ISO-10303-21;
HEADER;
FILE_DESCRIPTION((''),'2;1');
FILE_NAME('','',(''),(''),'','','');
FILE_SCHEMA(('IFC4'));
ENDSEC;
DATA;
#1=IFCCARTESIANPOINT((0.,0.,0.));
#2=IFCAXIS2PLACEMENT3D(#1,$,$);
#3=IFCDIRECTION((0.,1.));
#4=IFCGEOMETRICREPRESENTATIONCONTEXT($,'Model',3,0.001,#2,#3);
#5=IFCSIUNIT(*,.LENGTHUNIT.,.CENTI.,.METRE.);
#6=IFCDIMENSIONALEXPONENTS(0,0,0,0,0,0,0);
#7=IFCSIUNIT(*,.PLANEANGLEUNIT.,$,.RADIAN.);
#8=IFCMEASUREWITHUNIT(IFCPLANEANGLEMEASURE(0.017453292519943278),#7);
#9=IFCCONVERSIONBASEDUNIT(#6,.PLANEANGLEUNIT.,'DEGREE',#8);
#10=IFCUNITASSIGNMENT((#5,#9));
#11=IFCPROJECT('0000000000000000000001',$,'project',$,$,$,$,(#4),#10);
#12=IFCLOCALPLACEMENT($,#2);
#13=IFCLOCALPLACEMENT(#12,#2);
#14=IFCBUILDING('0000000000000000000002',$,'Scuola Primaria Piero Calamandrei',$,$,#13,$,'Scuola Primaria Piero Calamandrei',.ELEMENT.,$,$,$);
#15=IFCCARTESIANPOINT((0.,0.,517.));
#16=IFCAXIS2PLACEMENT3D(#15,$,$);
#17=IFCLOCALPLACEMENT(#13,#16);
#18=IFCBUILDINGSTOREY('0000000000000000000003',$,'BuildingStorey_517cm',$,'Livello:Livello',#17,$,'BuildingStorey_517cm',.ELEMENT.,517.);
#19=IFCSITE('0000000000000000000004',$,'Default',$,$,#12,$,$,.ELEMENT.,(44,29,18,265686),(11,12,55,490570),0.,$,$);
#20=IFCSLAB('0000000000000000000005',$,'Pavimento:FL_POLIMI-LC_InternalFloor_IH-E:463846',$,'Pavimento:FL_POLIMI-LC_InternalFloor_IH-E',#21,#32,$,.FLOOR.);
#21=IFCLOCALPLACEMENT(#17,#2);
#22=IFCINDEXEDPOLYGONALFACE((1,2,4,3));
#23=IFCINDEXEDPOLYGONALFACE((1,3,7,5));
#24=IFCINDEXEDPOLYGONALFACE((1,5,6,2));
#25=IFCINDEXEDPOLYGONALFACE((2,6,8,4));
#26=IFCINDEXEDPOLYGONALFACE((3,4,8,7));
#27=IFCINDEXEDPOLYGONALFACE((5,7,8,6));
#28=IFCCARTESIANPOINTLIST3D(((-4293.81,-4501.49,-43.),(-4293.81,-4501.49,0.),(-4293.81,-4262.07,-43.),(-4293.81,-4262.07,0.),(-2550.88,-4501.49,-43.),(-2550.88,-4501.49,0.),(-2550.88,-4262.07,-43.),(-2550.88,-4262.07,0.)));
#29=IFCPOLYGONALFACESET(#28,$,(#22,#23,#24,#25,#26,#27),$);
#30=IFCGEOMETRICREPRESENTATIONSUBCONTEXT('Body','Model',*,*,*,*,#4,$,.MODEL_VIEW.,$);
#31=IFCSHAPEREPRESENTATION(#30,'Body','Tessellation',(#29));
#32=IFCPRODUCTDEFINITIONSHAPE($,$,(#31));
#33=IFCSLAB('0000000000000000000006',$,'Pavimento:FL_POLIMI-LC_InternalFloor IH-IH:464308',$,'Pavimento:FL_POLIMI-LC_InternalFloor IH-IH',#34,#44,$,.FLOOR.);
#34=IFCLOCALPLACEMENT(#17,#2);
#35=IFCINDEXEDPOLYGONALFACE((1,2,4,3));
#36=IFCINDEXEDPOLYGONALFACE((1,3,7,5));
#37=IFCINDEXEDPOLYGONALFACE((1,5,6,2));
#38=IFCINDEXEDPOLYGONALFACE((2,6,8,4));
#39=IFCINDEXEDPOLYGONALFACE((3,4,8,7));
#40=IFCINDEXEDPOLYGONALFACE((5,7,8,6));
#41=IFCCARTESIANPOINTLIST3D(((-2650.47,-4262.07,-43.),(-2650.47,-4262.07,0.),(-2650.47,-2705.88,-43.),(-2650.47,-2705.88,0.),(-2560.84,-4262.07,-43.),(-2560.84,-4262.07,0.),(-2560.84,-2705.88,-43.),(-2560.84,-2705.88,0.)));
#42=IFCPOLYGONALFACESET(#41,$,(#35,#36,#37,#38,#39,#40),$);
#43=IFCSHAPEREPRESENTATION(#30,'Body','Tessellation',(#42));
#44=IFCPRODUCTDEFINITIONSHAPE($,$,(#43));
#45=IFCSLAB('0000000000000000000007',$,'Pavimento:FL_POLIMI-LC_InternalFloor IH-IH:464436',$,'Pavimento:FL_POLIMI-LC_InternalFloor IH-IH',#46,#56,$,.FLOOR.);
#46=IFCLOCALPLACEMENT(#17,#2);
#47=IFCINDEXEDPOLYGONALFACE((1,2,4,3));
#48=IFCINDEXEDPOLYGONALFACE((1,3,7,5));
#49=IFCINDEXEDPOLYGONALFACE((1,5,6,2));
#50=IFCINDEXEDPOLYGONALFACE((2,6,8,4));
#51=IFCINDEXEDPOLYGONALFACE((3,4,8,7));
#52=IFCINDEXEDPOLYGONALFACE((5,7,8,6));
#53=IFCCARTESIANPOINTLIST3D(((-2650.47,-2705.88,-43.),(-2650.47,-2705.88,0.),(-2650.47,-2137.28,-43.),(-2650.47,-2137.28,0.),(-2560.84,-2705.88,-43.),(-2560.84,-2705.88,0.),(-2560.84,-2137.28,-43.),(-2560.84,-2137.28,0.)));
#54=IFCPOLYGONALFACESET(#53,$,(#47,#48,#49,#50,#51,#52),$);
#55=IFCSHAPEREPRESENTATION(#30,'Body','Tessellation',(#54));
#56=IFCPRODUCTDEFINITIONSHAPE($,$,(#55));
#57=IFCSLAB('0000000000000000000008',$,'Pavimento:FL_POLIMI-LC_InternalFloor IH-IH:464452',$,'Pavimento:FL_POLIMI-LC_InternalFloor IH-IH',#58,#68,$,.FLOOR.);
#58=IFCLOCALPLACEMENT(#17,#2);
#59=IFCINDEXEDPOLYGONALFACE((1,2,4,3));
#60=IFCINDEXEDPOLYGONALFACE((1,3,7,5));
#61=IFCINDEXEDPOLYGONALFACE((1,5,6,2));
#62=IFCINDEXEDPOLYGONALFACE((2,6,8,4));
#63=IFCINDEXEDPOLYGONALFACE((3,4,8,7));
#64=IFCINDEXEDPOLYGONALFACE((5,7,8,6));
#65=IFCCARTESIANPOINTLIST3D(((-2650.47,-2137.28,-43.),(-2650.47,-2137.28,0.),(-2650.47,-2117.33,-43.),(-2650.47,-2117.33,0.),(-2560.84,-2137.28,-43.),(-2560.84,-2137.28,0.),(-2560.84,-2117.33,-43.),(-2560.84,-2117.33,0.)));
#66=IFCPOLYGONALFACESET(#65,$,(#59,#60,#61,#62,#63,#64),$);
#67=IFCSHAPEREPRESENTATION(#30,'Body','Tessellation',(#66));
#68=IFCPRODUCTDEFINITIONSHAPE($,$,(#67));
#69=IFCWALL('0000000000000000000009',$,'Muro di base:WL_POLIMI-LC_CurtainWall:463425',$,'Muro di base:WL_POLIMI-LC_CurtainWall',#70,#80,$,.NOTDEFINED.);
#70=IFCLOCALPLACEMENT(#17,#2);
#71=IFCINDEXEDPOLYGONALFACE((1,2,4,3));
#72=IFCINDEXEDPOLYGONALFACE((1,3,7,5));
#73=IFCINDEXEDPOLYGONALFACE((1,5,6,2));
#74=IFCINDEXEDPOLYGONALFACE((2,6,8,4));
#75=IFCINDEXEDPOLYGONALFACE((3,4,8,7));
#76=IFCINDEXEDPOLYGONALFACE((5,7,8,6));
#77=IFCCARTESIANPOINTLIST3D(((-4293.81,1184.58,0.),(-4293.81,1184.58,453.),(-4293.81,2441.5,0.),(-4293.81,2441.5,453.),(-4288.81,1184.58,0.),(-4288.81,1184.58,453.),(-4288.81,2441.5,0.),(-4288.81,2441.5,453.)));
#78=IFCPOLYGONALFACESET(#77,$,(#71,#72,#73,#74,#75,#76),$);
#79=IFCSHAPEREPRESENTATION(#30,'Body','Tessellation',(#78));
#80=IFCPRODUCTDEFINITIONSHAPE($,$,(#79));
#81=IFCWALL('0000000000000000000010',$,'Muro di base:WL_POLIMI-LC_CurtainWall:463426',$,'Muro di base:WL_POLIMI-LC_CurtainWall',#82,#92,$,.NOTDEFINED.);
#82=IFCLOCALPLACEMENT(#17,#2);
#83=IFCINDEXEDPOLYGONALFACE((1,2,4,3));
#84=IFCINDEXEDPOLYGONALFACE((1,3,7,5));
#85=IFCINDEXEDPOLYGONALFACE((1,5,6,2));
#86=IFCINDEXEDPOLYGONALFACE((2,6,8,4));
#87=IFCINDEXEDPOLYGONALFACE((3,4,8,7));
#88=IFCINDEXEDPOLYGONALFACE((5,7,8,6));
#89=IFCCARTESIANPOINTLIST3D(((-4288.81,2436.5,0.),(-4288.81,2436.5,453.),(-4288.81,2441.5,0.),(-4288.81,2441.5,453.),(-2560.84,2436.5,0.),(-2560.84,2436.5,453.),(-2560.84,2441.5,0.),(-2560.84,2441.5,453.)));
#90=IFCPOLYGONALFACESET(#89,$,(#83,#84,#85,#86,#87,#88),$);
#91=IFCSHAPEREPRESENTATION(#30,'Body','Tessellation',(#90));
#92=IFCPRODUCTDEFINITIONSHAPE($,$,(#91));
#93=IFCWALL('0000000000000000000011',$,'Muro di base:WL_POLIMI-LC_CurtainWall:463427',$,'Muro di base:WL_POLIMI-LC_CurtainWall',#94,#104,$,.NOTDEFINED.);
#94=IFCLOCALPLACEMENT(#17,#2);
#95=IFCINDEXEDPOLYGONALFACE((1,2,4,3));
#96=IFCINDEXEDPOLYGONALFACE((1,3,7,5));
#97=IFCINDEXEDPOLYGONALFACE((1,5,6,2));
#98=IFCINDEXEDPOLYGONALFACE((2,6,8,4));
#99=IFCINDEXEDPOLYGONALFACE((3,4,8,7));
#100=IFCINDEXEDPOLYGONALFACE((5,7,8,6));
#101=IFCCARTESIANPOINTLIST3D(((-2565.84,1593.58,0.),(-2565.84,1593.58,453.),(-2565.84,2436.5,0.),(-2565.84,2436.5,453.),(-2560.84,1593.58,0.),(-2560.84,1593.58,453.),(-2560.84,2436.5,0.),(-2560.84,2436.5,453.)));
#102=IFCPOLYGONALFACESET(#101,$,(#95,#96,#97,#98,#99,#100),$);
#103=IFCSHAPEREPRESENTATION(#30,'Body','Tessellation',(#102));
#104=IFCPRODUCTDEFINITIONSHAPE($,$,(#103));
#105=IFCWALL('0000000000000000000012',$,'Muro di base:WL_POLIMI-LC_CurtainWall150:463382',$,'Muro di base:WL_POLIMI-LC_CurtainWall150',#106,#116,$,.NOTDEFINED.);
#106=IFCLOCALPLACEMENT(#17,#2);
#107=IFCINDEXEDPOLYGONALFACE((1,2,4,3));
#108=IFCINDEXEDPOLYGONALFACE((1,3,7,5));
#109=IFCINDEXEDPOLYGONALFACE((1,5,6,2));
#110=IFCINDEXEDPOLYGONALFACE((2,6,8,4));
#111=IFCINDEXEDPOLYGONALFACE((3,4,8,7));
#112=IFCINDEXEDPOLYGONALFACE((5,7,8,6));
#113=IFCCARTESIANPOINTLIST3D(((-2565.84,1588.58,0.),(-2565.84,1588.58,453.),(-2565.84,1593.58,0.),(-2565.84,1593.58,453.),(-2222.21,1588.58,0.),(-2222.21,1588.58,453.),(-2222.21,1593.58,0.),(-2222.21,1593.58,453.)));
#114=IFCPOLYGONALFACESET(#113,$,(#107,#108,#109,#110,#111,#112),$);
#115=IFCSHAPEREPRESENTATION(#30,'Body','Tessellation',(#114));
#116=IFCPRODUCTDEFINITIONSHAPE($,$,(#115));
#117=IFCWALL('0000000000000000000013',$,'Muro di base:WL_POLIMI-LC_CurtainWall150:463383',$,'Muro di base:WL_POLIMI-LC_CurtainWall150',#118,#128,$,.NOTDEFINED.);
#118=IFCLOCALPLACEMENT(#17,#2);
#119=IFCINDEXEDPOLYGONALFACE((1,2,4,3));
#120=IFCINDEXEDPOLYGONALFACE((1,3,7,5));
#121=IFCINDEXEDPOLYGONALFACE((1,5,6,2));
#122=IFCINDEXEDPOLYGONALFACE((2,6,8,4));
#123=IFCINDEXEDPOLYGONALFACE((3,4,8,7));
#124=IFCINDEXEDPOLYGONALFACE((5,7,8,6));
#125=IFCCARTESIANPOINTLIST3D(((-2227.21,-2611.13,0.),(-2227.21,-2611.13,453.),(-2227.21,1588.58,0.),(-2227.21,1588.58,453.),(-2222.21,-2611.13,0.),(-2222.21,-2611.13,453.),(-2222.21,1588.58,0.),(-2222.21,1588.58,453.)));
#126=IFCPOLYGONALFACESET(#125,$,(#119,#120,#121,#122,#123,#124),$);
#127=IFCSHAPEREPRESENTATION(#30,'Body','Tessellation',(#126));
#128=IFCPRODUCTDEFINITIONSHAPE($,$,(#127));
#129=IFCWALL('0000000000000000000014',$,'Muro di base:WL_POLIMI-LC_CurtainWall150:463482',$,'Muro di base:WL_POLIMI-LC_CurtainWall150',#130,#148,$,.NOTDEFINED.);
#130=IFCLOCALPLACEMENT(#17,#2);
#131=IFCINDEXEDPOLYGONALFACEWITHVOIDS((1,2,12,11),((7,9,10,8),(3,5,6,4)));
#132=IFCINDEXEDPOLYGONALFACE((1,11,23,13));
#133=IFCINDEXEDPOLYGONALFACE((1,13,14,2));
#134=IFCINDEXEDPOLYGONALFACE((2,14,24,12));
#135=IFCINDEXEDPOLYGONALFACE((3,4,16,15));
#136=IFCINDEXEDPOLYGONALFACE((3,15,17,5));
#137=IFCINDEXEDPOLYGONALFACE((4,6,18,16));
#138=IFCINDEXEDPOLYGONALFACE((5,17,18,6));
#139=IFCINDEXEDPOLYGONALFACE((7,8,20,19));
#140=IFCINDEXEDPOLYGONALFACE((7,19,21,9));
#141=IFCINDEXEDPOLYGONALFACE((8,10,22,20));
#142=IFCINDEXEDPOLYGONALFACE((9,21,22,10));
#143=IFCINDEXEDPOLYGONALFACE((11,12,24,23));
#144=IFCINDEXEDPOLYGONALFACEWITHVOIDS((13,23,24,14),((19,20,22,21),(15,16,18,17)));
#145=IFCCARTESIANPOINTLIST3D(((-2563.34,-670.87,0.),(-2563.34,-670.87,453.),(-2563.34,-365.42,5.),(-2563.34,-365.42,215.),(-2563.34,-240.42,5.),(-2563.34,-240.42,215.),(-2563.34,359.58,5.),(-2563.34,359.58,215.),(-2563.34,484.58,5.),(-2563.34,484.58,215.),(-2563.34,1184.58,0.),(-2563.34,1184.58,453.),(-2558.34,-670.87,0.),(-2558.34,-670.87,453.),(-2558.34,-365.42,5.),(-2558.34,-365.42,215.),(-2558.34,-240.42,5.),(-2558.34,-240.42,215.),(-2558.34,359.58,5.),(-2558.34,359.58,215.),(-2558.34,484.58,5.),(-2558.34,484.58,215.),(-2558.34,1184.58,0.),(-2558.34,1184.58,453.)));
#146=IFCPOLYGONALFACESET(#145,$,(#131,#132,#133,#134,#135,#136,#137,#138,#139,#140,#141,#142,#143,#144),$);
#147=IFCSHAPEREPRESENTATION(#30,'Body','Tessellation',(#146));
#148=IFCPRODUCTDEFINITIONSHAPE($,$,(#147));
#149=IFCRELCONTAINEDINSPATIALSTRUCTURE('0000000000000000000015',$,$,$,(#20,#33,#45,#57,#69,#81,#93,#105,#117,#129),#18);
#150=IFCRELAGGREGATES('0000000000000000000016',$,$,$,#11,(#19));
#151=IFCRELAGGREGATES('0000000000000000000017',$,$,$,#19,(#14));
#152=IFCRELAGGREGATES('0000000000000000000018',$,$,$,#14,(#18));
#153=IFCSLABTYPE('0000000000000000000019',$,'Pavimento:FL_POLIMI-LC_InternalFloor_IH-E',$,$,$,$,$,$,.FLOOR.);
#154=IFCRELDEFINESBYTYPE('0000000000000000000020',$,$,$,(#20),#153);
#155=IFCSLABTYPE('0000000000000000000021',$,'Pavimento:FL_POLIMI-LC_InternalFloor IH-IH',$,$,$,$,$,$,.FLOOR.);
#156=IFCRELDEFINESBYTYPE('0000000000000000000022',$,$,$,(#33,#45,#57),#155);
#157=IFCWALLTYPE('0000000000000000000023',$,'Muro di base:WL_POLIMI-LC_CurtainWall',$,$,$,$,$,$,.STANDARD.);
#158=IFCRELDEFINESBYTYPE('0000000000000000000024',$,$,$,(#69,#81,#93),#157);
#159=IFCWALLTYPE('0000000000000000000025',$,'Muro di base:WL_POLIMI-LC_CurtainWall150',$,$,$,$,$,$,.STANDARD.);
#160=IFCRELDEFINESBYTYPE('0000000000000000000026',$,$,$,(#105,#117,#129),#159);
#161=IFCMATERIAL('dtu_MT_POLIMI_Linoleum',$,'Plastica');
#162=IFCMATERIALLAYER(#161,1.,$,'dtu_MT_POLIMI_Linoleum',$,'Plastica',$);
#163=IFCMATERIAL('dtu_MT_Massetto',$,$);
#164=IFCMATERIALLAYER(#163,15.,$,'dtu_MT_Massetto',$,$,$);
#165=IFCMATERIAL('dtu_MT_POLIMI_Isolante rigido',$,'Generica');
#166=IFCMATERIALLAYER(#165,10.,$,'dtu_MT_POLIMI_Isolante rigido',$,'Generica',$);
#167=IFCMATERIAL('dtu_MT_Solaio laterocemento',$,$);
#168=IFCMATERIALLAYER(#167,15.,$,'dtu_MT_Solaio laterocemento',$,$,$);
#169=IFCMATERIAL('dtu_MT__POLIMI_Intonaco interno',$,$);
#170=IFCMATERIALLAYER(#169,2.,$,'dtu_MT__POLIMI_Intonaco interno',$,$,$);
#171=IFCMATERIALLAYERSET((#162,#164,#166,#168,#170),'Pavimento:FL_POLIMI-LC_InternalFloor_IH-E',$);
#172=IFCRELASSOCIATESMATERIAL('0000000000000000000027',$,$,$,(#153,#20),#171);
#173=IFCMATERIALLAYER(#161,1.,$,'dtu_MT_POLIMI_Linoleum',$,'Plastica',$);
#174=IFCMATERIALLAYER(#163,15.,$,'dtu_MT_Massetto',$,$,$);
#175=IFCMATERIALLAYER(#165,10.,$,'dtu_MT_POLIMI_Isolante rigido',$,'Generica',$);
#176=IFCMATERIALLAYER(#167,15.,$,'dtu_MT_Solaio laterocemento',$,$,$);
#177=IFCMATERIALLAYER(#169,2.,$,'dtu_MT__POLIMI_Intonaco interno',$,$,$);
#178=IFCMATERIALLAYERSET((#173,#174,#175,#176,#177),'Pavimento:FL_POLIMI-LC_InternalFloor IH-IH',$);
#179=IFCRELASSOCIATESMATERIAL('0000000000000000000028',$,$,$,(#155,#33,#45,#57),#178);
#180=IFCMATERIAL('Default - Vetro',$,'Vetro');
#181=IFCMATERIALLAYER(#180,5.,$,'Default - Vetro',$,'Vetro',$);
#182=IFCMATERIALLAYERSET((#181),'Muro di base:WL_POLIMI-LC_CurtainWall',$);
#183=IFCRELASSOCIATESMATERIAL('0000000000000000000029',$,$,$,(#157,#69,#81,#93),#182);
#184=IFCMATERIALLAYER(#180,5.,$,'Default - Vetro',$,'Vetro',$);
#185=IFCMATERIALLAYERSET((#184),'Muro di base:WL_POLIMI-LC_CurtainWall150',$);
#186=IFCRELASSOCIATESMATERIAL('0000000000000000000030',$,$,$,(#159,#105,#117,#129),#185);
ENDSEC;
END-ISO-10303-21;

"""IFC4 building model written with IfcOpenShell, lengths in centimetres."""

from ifc_helpers import new_model, entity, si_unit, converted_unit, direction, frame, frame_2d, origin, place, context, subcontext, project, spatial, polyline, rectangle, extrude, clip, bounded_halfspace, material, layer, layer_set, layer_usage, type_object, element, save


model = new_model("IFC4")

# Units and contexts
model_context = context("Model", 3, precision=0.001, world=origin(), true_north=direction((0.0, 1.0)))
body_context = subcontext(model_context, "Body", "Model", "MODEL_VIEW")
ifc_project = project(units=[si_unit("LENGTHUNIT", "METRE", prefix="CENTI"), converted_unit("PLANEANGLEUNIT", "DEGREE", entity("IfcPlaneAngleMeasure", 0.017453292519943278), si_unit("PLANEANGLEUNIT", "RADIAN"), dimensions=[0, 0, 0, 0, 0, 0, 0])], contexts=[model_context])

# Site, building, storey
site_placement = place(None, origin())
site = spatial("IfcSite", under=ifc_project, at=site_placement, Name="Default", CompositionType="ELEMENT", RefLatitude=(44, 29, 18, 265686), RefLongitude=(11, 12, 55, 490570), RefElevation=0.0)
building_placement = place(site_placement, origin())
building = spatial("IfcBuilding", under=site, at=building_placement, Name="Scuola Primaria Piero Calamandrei", LongName="Scuola Primaria Piero Calamandrei", CompositionType="ELEMENT")
storey_placement = place(building_placement, frame((0.0, 0.0, 517.0)))
storey = spatial("IfcBuildingStorey", under=building, at=storey_placement, Name="BuildingStorey_517cm", ObjectType="Livello:Livello", LongName="BuildingStorey_517cm", CompositionType="ELEMENT", Elevation=517.0)

# Slabs
ifc_material_1 = material(Name="dtu_MT_POLIMI_Linoleum", Category="Plastica")
ifc_layer_1 = layer(ifc_material_1, 1.0, Name="dtu_MT_POLIMI_Linoleum", Category="Plastica")
ifc_material_2 = material(Name="dtu_MT_Massetto")
ifc_layer_2 = layer(ifc_material_2, 15.0, Name="dtu_MT_Massetto")
ifc_material_3 = material(Name="dtu_MT_POLIMI_Isolante rigido", Category="Generica")
ifc_layer_3 = layer(ifc_material_3, 10.0, Name="dtu_MT_POLIMI_Isolante rigido", Category="Generica")
ifc_material_4 = material(Name="dtu_MT_Solaio laterocemento")
ifc_layer_4 = layer(ifc_material_4, 15.0, Name="dtu_MT_Solaio laterocemento")
ifc_material_5 = material(Name="dtu_MT__POLIMI_Intonaco interno")
ifc_layer_5 = layer(ifc_material_5, 2.0, Name="dtu_MT__POLIMI_Intonaco interno")
ifc_layer_set_1 = layer_set([ifc_layer_1, ifc_layer_2, ifc_layer_3, ifc_layer_4, ifc_layer_5], Name="Pavimento:FL_POLIMI-LC_InternalFloor_IH-E")
slab_type_1 = type_object("IfcSlabType", Name="Pavimento:FL_POLIMI-LC_InternalFloor_IH-E", PredefinedType="FLOOR", material=ifc_layer_set_1)
ifc_layer_usage_1 = layer_usage(ifc_layer_set_1, "AXIS3", "POSITIVE", 0.0)
slab_1_placement = place(storey_placement, origin())
element("IfcSlab", 1, at=slab_1_placement, inside=storey, type_object=slab_type_1, material=ifc_layer_usage_1, Name="Pavimento:FL_POLIMI-LC_InternalFloor_IH-E:463846", ObjectType="Pavimento:FL_POLIMI-LC_InternalFloor_IH-E", PredefinedType="FLOOR", context=body_context, shape_type="SweptSolid", body=[
    extrude(rectangle(XDim=239.41, YDim=1742.93, at=frame_2d((0.0, 0.0), x_axis=(1.0, 0.0))), frame((-3422.34, -4381.78, 0.0), z_axis=(0.0, 0.0, -1.0), x_axis=(0.0, 1.0, 0.0)), (0.0, 0.0, 1.0), 43.0),
])
ifc_layer_6 = layer(ifc_material_1, 1.0, Name="dtu_MT_POLIMI_Linoleum", Category="Plastica")
ifc_layer_7 = layer(ifc_material_2, 15.0, Name="dtu_MT_Massetto")
ifc_layer_8 = layer(ifc_material_3, 10.0, Name="dtu_MT_POLIMI_Isolante rigido", Category="Generica")
ifc_layer_9 = layer(ifc_material_4, 15.0, Name="dtu_MT_Solaio laterocemento")
ifc_layer_10 = layer(ifc_material_5, 2.0, Name="dtu_MT__POLIMI_Intonaco interno")
ifc_layer_set_2 = layer_set([ifc_layer_6, ifc_layer_7, ifc_layer_8, ifc_layer_9, ifc_layer_10], Name="Pavimento:FL_POLIMI-LC_InternalFloor IH-IH")
ifc_layer_usage_2 = layer_usage(ifc_layer_set_2, "AXIS3", "POSITIVE", 0.0)
slab_type_2 = type_object("IfcSlabType", Name="Pavimento:FL_POLIMI-LC_InternalFloor IH-IH", PredefinedType="FLOOR", material=ifc_layer_set_2)
slab_2_placement = place(storey_placement, origin())
element("IfcSlab", 2, at=slab_2_placement, inside=storey, type_object=slab_type_2, material=ifc_layer_usage_2, Name="Pavimento:FL_POLIMI-LC_InternalFloor IH-IH:464308", ObjectType="Pavimento:FL_POLIMI-LC_InternalFloor IH-IH", PredefinedType="FLOOR", context=body_context, shape_type="SweptSolid", body=[
    extrude(rectangle(XDim=1556.19, YDim=89.64, at=frame_2d((0.0, 0.0), x_axis=(1.0, 0.0))), frame((-2605.65, -3483.98, 0.0), z_axis=(0.0, 0.0, -1.0), x_axis=(0.0, 1.0, 0.0)), (0.0, 0.0, 1.0), 43.0),
])
ifc_layer_usage_3 = layer_usage(ifc_layer_set_2, "AXIS3", "POSITIVE", 0.0)
slab_3_placement = place(storey_placement, origin())
element("IfcSlab", 3, at=slab_3_placement, inside=storey, type_object=slab_type_2, material=ifc_layer_usage_3, Name="Pavimento:FL_POLIMI-LC_InternalFloor IH-IH:464436", ObjectType="Pavimento:FL_POLIMI-LC_InternalFloor IH-IH", PredefinedType="FLOOR", context=body_context, shape_type="SweptSolid", body=[
    extrude(rectangle(XDim=568.61, YDim=89.64, at=frame_2d((0.0, 0.0), x_axis=(1.0, 0.0))), frame((-2605.65, -2421.58, 0.0), z_axis=(0.0, 0.0, -1.0), x_axis=(0.0, 1.0, 0.0)), (0.0, 0.0, 1.0), 43.0),
])
ifc_layer_usage_4 = layer_usage(ifc_layer_set_2, "AXIS3", "POSITIVE", 0.0)
slab_4_placement = place(storey_placement, origin())
element("IfcSlab", 4, at=slab_4_placement, inside=storey, type_object=slab_type_2, material=ifc_layer_usage_4, Name="Pavimento:FL_POLIMI-LC_InternalFloor IH-IH:464452", ObjectType="Pavimento:FL_POLIMI-LC_InternalFloor IH-IH", PredefinedType="FLOOR", context=body_context, shape_type="SweptSolid", body=[
    extrude(rectangle(XDim=19.95, YDim=89.64, at=frame_2d((0.0, 0.0), x_axis=(1.0, 0.0))), frame((-2605.65, -2127.3, 0.0), z_axis=(0.0, 0.0, -1.0), x_axis=(0.0, 1.0, 0.0)), (0.0, 0.0, 1.0), 43.0),
])

# Walls
ifc_material_6 = material(Name="Default - Vetro", Category="Vetro")
ifc_layer_11 = layer(ifc_material_6, 5.0, Name="Default - Vetro", Category="Vetro")
ifc_layer_set_3 = layer_set([ifc_layer_11], Name="Muro di base:WL_POLIMI-LC_CurtainWall")
ifc_layer_usage_5 = layer_usage(ifc_layer_set_3, "AXIS2", "NEGATIVE", 2.5)
wall_type_1 = type_object("IfcWallType", Name="Muro di base:WL_POLIMI-LC_CurtainWall", PredefinedType="STANDARD", material=ifc_layer_set_3)
wall_1_placement = place(storey_placement, frame((-4291.31, 1184.58, 0.0), z_axis=(0.0, 0.0, 1.0), x_axis=(0.0, 1.0, 0.0)))
element("IfcWall", 5, at=wall_1_placement, inside=storey, type_object=wall_type_1, material=ifc_layer_usage_5, Name="Muro di base:WL_POLIMI-LC_CurtainWall:463425", ObjectType="Muro di base:WL_POLIMI-LC_CurtainWall", PredefinedType="NOTDEFINED", context=body_context, shape_type="Clipping", body=[
    clip(extrude(rectangle(XDim=1256.92, YDim=5.0, at=frame_2d((628.46, 0.0), x_axis=(-1.0, 0.0))), origin(), (0.0, 0.0, 1.0), 453.0), bounded_halfspace(frame((0.0, -2.5, 453.0), z_axis=(0.0, 0.0, 1.0), x_axis=(0.0, -1.0, 0.0)), False, frame((0.0, -2.5, 453.0)), polyline([(0.0, 0.0), (10.75, 0.0), (1251.92, 0.0), (1256.92, 0.0), (1256.92, 5.0), (0.0, 5.0), (0.0, 0.0)]))),
])
ifc_layer_usage_6 = layer_usage(ifc_layer_set_3, "AXIS2", "NEGATIVE", 2.5)
wall_2_placement = place(storey_placement, frame((-4288.81, 2439.0, 0.0)))
element("IfcWall", 6, at=wall_2_placement, inside=storey, type_object=wall_type_1, material=ifc_layer_usage_6, Name="Muro di base:WL_POLIMI-LC_CurtainWall:463426", ObjectType="Muro di base:WL_POLIMI-LC_CurtainWall", PredefinedType="NOTDEFINED", context=body_context, shape_type="Clipping", body=[
    clip(extrude(rectangle(XDim=1727.97, YDim=5.0, at=frame_2d((863.99, 0.0), x_axis=(-1.0, 0.0))), origin(), (0.0, 0.0, 1.0), 453.0), bounded_halfspace(frame((0.0, -2.5, 453.0)), False, frame((0.0, -2.5, 453.0)), polyline([(0.0, 0.0), (1722.97, 0.0), (1727.97, 0.0), (1727.97, 5.0), (0.0, 5.0), (0.0, 0.0)]))),
])
ifc_layer_usage_7 = layer_usage(ifc_layer_set_3, "AXIS2", "NEGATIVE", 2.5)
wall_3_placement = place(storey_placement, frame((-2563.34, 2436.5, 0.0), z_axis=(0.0, 0.0, 1.0), x_axis=(0.0, -1.0, 0.0)))
element("IfcWall", 7, at=wall_3_placement, inside=storey, type_object=wall_type_1, material=ifc_layer_usage_7, Name="Muro di base:WL_POLIMI-LC_CurtainWall:463427", ObjectType="Muro di base:WL_POLIMI-LC_CurtainWall", PredefinedType="NOTDEFINED", context=body_context, shape_type="Clipping", body=[
    clip(extrude(rectangle(XDim=842.92, YDim=5.0, at=frame_2d((421.46, 0.0), x_axis=(-1.0, 0.0))), origin(), (0.0, 0.0, 1.0), 453.0), bounded_halfspace(frame((0.0, -2.5, 453.0), z_axis=(0.0, 0.0, 1.0), x_axis=(0.0, 1.0, 0.0)), False, frame((0.0, -2.5, 453.0)), polyline([(0.0, 0.0), (842.92, 0.0), (842.92, 5.0), (0.0, 5.0), (0.0, 0.0)]))),
])
ifc_layer_12 = layer(ifc_material_6, 5.0, Name="Default - Vetro", Category="Vetro")
ifc_layer_set_4 = layer_set([ifc_layer_12], Name="Muro di base:WL_POLIMI-LC_CurtainWall150")
ifc_layer_usage_8 = layer_usage(ifc_layer_set_4, "AXIS2", "NEGATIVE", 2.5)
wall_type_2 = type_object("IfcWallType", Name="Muro di base:WL_POLIMI-LC_CurtainWall150", PredefinedType="STANDARD", material=ifc_layer_set_4)
wall_4_placement = place(storey_placement, frame((-2565.84, 1591.08, 0.0)))
element("IfcWall", 8, at=wall_4_placement, inside=storey, type_object=wall_type_2, material=ifc_layer_usage_8, Name="Muro di base:WL_POLIMI-LC_CurtainWall150:463382", ObjectType="Muro di base:WL_POLIMI-LC_CurtainWall150", PredefinedType="NOTDEFINED", context=body_context, shape_type="Clipping", body=[
    clip(extrude(rectangle(XDim=343.63, YDim=5.0, at=frame_2d((171.81, 0.0), x_axis=(-1.0, 0.0))), origin(), (0.0, 0.0, 1.0), 453.0), bounded_halfspace(frame((5.0, -2.5, 453.0)), False, frame((5.0, -2.5, 453.0)), polyline([(0.0, 0.0), (2.5, 0.0), (333.63, 0.0), (338.63, 0.0), (338.63, 5.0), (0.0, 5.0), (0.0, 0.0)]))),
])
ifc_layer_usage_9 = layer_usage(ifc_layer_set_4, "AXIS2", "NEGATIVE", 2.5)
wall_5_placement = place(storey_placement, frame((-2224.71, 1588.58, 0.0), z_axis=(0.0, 0.0, 1.0), x_axis=(0.0, -1.0, 0.0)))
element("IfcWall", 9, at=wall_5_placement, inside=storey, type_object=wall_type_2, material=ifc_layer_usage_9, Name="Muro di base:WL_POLIMI-LC_CurtainWall150:463383", ObjectType="Muro di base:WL_POLIMI-LC_CurtainWall150", PredefinedType="NOTDEFINED", context=body_context, shape_type="Clipping", body=[
    clip(extrude(rectangle(XDim=4199.71, YDim=5.0, at=frame_2d((2099.85, 0.0), x_axis=(-1.0, 0.0))), origin(), (0.0, 0.0, 1.0), 453.0), bounded_halfspace(frame((0.0, -2.5, 453.0), z_axis=(0.0, 0.0, 1.0), x_axis=(0.0, 1.0, 0.0)), False, frame((0.0, -2.5, 453.0)), polyline([(0.0, 0.0), (4199.71, 0.0), (4199.71, 5.0), (4194.71, 5.0), (0.0, 5.0), (0.0, 0.0)]))),
])

# Wall, openings
ifc_layer_usage_10 = layer_usage(ifc_layer_set_4, "AXIS2", "NEGATIVE", 2.5)
wall_6_placement = place(storey_placement, frame((-2560.84, -670.87, 0.0), z_axis=(0.0, 0.0, 1.0), x_axis=(0.0, 1.0, 0.0)))
wall_6 = element("IfcWall", 10, at=wall_6_placement, inside=storey, type_object=wall_type_2, material=ifc_layer_usage_10, Name="Muro di base:WL_POLIMI-LC_CurtainWall150:463482", ObjectType="Muro di base:WL_POLIMI-LC_CurtainWall150", PredefinedType="NOTDEFINED", context=body_context, shape_type="SweptSolid", body=[
    extrude(rectangle(XDim=1855.45, YDim=5.0, at=frame_2d((927.73, 0.0), x_axis=(-1.0, 0.0))), origin(), (0.0, 0.0, 1.0), 453.0),
])
opening_1_placement = place(wall_6_placement, frame((1155.45, 2.5, 5.0)))
element("IfcOpeningElement", 11, at=opening_1_placement, cuts=wall_6, PredefinedType="OPENING", context=body_context, shape_type="SweptSolid", body=[
    extrude(rectangle(XDim=210.0, YDim=125.0, at=frame_2d((105.0, 62.5), x_axis=(-1.0, 0.0))), frame((0.0, 0.0, 0.0), z_axis=(0.0, -1.0, 0.0), x_axis=(0.0, 0.0, 1.0)), (0.0, 0.0, 1.0), 5.0),
])
opening_2_placement = place(wall_6_placement, frame((430.45, 2.5, 5.0)))
element("IfcOpeningElement", 12, at=opening_2_placement, cuts=wall_6, PredefinedType="OPENING", context=body_context, shape_type="SweptSolid", body=[
    extrude(rectangle(XDim=210.0, YDim=125.0, at=frame_2d((105.0, 62.5), x_axis=(-1.0, 0.0))), frame((0.0, 0.0, 0.0), z_axis=(0.0, -1.0, 0.0), x_axis=(0.0, 0.0, 1.0)), (0.0, 0.0, 1.0), 5.0),
])

save(model, "model.ifc")
